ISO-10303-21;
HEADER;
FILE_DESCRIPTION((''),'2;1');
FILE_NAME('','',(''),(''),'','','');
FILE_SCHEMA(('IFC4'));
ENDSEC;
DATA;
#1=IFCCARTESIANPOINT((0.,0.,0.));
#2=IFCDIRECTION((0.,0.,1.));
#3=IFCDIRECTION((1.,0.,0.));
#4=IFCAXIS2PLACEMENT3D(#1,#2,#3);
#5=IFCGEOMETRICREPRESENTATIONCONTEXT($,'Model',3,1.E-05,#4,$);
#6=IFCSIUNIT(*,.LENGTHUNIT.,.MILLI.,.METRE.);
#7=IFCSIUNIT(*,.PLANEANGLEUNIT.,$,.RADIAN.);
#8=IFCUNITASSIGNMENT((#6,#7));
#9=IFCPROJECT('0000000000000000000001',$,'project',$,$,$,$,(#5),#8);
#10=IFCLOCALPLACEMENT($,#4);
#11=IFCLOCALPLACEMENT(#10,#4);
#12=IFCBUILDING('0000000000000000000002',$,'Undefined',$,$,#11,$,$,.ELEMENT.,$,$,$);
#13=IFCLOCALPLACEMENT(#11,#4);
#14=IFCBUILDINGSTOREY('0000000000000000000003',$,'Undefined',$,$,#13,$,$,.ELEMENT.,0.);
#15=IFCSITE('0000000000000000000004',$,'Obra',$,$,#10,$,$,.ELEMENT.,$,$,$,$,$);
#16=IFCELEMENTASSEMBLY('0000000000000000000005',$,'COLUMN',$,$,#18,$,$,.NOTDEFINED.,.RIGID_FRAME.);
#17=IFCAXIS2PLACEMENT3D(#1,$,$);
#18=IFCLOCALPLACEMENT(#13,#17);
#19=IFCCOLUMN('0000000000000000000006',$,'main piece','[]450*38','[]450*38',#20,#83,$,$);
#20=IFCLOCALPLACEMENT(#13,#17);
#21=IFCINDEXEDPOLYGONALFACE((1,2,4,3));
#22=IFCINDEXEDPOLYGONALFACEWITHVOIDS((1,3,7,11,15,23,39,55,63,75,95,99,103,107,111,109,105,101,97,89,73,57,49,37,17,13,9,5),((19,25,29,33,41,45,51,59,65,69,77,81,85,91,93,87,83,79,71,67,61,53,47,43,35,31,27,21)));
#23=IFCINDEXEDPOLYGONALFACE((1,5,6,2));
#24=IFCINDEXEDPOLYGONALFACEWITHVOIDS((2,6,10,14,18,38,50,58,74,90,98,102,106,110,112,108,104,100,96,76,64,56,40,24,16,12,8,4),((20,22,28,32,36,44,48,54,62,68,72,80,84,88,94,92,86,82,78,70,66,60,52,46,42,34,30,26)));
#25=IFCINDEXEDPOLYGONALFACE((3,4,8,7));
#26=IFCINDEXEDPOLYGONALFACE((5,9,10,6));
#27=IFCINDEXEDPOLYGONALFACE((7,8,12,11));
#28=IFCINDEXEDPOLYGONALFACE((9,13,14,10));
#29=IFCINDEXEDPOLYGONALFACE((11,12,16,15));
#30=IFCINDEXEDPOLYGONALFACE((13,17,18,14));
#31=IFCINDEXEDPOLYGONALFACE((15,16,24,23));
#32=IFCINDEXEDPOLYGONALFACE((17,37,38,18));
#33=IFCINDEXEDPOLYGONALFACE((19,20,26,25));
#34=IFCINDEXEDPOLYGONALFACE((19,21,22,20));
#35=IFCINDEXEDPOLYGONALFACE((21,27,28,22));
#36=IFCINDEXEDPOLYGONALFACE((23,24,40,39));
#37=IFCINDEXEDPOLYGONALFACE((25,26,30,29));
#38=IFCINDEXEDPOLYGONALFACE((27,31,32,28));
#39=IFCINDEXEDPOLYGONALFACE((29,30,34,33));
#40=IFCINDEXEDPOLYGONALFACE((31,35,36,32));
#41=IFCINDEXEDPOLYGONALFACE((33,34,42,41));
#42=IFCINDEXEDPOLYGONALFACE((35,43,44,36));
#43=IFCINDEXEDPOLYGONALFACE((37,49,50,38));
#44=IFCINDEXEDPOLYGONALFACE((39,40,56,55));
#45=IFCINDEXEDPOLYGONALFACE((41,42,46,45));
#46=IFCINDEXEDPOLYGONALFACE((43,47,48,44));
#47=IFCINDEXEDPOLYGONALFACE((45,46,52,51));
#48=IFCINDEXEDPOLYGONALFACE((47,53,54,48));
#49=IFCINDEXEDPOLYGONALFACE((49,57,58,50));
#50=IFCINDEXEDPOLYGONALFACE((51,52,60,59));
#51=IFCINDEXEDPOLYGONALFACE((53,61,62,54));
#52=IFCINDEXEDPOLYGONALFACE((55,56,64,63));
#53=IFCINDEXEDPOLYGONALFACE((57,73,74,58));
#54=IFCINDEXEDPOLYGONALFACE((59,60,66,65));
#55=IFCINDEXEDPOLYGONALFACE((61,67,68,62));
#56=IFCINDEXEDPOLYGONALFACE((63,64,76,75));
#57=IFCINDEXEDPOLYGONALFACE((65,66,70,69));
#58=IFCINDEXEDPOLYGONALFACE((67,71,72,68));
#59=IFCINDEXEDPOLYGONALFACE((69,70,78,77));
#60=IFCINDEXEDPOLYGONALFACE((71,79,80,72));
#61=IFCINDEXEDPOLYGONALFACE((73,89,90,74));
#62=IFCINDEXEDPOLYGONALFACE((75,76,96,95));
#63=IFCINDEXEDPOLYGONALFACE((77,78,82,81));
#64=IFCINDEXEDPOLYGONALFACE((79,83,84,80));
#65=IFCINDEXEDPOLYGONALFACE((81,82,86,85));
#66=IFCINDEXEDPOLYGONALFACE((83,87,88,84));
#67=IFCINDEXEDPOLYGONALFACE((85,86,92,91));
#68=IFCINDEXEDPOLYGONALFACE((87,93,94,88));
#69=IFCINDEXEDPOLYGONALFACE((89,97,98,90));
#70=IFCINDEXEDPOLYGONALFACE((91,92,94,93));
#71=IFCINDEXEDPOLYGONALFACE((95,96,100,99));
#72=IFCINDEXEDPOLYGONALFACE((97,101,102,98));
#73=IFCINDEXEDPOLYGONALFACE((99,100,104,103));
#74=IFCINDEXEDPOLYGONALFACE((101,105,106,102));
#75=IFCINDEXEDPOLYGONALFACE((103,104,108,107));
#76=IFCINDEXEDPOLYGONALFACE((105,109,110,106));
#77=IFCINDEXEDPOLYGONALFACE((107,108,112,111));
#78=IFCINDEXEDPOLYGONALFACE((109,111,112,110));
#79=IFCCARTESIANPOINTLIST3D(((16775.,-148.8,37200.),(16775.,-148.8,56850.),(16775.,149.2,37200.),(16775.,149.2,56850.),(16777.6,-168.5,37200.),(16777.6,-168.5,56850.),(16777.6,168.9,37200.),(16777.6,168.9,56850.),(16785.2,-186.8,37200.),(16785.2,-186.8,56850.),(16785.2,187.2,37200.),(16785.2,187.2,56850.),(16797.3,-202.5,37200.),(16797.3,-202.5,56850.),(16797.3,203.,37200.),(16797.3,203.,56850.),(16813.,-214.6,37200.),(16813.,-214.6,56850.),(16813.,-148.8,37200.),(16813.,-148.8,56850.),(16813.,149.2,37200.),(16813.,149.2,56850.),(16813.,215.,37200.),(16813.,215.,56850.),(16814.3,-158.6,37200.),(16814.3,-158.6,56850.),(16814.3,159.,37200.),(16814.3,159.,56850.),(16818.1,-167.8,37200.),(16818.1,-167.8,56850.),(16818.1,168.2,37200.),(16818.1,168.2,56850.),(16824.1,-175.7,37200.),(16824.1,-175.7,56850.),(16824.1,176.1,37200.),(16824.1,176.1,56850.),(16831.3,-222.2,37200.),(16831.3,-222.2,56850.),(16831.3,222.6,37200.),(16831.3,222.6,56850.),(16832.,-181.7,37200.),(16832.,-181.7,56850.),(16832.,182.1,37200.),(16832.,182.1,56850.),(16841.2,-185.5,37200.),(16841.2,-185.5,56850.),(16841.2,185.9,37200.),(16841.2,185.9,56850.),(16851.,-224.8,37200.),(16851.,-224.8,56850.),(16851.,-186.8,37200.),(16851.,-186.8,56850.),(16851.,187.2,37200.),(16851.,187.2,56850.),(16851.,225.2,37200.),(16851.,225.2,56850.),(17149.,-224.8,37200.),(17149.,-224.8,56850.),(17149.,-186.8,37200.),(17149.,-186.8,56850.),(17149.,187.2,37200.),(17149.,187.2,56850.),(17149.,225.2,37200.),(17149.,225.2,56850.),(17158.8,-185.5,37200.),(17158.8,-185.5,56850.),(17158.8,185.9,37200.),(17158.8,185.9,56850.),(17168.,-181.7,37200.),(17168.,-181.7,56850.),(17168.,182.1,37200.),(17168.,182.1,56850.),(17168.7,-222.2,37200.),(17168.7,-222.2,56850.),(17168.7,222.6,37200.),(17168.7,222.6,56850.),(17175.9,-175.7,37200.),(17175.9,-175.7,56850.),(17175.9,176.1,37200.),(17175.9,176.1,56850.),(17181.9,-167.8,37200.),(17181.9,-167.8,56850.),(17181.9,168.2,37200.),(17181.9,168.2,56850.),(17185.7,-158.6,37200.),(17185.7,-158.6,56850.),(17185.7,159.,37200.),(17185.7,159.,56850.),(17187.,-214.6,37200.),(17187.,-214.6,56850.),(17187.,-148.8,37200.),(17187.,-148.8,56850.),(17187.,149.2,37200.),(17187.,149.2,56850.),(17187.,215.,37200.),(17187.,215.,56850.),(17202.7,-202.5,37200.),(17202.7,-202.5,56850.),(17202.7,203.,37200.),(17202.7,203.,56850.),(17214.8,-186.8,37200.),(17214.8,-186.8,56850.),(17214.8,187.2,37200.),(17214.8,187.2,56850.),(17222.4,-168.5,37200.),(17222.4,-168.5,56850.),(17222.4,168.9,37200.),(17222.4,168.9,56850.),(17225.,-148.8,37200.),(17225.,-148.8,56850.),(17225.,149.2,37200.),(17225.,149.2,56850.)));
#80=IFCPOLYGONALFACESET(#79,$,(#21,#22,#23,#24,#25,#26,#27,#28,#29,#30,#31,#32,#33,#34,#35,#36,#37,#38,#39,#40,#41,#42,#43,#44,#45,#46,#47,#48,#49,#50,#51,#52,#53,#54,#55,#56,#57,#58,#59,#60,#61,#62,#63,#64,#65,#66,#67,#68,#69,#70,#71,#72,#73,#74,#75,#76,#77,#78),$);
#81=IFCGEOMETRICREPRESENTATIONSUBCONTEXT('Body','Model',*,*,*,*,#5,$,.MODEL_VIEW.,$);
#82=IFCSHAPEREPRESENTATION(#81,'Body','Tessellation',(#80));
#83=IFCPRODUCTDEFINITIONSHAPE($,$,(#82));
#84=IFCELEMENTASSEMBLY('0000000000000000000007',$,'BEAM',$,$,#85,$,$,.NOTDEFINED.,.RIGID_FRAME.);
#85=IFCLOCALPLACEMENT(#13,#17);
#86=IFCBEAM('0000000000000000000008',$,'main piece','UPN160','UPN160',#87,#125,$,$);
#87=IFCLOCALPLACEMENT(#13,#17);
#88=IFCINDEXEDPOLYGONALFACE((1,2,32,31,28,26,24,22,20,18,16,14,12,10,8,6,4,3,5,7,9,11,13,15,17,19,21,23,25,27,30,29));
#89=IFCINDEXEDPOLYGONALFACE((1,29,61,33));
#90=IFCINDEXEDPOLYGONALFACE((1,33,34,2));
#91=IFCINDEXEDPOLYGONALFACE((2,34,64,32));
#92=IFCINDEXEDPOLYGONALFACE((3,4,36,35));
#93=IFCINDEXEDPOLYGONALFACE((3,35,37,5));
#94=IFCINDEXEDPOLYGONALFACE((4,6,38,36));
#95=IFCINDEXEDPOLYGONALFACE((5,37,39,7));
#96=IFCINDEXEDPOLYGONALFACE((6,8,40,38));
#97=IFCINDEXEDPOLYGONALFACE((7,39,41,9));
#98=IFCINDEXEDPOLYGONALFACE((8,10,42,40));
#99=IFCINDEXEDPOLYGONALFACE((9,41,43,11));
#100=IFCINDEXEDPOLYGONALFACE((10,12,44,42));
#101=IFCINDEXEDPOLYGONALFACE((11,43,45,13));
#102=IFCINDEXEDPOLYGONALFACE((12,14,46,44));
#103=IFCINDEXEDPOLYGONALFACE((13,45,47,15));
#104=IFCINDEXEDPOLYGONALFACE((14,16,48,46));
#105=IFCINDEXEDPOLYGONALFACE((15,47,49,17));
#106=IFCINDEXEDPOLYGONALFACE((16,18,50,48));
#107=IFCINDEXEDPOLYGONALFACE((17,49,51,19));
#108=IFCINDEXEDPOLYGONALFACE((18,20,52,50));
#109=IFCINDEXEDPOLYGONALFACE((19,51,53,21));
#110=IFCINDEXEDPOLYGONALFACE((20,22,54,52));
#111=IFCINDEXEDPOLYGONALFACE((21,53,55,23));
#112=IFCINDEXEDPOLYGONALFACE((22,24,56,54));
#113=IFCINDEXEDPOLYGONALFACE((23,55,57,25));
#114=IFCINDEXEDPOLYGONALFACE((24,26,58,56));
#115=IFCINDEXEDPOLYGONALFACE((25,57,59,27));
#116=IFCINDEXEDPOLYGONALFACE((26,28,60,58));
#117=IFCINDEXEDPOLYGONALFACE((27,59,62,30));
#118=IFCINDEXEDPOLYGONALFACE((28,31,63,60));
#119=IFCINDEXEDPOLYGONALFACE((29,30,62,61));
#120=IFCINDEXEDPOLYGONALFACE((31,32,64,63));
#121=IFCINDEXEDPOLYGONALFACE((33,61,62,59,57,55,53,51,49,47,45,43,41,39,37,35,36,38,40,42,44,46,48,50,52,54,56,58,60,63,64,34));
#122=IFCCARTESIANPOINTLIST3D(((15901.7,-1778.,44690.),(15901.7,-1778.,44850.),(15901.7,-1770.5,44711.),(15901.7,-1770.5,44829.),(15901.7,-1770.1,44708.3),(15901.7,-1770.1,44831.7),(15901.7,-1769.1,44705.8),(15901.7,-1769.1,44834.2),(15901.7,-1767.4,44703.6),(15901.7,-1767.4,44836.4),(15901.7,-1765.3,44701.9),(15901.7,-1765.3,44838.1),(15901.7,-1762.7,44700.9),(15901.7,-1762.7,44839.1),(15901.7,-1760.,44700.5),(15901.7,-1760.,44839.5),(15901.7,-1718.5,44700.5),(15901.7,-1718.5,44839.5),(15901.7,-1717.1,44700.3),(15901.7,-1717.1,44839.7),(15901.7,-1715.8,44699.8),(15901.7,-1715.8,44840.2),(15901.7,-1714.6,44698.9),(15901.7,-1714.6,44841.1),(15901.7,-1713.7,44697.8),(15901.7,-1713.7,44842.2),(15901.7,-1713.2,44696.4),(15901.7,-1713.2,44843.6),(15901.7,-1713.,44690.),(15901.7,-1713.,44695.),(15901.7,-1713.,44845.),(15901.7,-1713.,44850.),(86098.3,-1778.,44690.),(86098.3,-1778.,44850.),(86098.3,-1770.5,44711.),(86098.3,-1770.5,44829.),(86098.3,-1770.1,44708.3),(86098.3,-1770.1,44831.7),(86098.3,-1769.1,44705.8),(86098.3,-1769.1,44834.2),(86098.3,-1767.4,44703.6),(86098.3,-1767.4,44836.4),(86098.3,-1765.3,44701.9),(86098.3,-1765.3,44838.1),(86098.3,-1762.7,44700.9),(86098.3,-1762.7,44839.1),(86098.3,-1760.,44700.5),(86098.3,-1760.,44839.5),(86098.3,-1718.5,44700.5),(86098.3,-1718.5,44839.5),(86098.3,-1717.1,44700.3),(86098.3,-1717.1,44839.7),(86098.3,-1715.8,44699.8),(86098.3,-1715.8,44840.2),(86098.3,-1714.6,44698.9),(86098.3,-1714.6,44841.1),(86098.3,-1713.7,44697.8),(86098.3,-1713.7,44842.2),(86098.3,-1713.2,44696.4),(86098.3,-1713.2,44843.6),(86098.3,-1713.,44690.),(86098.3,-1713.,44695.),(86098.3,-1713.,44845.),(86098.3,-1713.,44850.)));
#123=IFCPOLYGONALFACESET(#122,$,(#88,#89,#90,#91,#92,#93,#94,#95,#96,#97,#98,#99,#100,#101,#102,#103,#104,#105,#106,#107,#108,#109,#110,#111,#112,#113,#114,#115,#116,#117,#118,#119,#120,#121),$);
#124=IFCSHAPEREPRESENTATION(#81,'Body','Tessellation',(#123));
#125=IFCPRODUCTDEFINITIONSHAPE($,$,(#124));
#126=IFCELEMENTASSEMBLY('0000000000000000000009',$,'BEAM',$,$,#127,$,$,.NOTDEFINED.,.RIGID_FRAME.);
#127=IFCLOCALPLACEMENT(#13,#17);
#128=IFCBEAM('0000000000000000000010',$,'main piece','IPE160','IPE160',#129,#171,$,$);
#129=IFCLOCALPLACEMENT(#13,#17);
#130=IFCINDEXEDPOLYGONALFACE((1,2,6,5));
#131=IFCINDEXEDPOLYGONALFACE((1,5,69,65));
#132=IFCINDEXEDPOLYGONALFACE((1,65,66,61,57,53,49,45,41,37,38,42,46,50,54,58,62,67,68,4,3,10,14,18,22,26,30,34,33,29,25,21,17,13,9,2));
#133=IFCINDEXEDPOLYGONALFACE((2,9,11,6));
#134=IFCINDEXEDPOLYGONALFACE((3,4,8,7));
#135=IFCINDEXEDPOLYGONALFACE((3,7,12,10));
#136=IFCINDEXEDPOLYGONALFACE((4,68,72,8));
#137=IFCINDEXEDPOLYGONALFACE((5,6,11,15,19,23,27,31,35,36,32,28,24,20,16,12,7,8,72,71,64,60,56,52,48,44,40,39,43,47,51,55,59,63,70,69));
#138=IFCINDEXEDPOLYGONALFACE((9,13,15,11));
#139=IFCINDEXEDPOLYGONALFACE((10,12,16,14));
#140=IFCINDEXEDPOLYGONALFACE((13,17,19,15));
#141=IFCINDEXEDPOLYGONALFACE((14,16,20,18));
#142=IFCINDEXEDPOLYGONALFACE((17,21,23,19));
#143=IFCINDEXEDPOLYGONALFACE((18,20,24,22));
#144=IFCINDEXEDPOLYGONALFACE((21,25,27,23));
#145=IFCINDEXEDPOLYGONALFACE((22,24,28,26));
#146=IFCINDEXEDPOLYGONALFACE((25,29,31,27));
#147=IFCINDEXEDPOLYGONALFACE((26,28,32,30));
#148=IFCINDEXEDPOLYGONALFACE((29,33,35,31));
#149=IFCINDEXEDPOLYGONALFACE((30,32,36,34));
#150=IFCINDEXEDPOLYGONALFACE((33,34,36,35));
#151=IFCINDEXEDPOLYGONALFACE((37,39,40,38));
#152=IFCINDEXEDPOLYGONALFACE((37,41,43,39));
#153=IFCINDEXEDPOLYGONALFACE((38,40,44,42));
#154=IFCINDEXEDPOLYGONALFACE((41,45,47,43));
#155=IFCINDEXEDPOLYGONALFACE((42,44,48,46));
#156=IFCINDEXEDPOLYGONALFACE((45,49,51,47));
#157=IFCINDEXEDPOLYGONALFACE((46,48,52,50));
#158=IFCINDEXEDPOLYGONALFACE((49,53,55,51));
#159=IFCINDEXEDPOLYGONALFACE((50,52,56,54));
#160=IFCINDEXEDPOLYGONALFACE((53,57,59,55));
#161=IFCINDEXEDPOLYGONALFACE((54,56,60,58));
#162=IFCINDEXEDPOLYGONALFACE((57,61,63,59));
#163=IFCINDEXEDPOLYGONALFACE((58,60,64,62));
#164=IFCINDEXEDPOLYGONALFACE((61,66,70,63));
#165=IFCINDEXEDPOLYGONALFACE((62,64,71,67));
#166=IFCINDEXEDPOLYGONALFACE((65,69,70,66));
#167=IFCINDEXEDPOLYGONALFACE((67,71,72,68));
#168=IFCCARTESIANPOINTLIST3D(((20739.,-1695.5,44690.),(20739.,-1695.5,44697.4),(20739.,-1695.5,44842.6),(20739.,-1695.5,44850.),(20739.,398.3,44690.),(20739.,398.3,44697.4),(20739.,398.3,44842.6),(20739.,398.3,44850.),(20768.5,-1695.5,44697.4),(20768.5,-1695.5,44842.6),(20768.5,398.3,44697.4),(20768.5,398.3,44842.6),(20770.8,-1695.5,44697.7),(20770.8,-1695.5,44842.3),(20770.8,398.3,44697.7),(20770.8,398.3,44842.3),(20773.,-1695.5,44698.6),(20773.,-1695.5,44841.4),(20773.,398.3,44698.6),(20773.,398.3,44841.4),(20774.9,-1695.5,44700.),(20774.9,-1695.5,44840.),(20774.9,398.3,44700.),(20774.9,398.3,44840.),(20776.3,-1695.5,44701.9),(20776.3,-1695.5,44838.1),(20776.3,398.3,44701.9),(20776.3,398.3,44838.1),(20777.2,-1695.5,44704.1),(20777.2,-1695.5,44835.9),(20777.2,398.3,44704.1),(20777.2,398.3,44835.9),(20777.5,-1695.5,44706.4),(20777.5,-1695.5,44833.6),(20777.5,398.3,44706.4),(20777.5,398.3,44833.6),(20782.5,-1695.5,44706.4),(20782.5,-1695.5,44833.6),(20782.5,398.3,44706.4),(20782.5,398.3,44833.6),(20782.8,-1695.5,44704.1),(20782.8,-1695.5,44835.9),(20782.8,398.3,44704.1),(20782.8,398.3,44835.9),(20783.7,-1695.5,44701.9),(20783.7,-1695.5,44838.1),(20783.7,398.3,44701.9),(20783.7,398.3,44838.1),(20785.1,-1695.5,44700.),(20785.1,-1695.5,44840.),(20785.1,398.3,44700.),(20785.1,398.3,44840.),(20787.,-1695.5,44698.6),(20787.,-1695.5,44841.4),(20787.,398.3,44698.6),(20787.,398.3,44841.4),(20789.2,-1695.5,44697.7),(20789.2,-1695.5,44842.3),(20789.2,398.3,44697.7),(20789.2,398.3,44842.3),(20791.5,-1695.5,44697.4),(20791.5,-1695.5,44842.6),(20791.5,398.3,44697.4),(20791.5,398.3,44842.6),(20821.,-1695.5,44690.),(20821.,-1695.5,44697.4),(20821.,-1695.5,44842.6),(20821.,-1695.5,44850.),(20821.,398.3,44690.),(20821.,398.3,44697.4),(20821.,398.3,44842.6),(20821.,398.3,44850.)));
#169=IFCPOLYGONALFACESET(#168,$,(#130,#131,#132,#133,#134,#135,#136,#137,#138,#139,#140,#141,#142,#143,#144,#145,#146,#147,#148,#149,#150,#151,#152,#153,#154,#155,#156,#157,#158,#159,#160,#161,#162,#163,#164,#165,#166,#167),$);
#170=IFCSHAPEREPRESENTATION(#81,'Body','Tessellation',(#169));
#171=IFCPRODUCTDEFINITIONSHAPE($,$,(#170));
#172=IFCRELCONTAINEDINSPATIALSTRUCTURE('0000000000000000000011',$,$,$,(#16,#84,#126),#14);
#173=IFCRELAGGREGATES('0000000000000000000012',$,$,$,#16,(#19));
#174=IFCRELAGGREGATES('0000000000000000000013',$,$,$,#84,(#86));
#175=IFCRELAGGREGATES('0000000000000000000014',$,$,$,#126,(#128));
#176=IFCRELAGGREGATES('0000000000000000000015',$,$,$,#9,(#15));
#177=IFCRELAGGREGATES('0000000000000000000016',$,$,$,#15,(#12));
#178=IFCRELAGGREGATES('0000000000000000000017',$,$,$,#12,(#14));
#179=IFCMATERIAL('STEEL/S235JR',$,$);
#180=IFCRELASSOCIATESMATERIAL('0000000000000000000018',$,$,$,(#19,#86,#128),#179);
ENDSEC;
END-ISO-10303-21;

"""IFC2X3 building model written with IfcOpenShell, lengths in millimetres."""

from ifc_helpers import new_model, si_unit, frame, origin_with_axes, origin_2d_with_axis, place, context, subcontext, project, spatial, hollow_rectangle, i_section, u_section, extrude, material, element, aggregate, save


model = new_model("IFC2X3")

# Units and contexts
model_context = context("Model", 3, precision=1e-05, world=origin_with_axes())
body_context = subcontext(model_context, "Body", "Model", "MODEL_VIEW")
ifc_project = project(units=[si_unit("LENGTHUNIT", "METRE", prefix="MILLI"), si_unit("PLANEANGLEUNIT", "RADIAN")], contexts=[model_context])

# Site, building, storey
site_placement = place(None, origin_with_axes())
site = spatial("IfcSite", under=ifc_project, at=site_placement, Name="Obra", CompositionType="ELEMENT")
building_placement = place(site_placement, origin_with_axes())
building = spatial("IfcBuilding", under=site, at=building_placement, Name="Undefined", CompositionType="ELEMENT")
storey_placement = place(building_placement, origin_with_axes())
storey = spatial("IfcBuildingStorey", under=building, at=storey_placement, Name="Undefined", CompositionType="ELEMENT", Elevation=0.0)

# Element assembly, column
assembly_1_placement = place(storey_placement, origin_with_axes())
assembly_1 = element("IfcElementAssembly", 1, at=assembly_1_placement, inside=storey, Name="COLUMN", AssemblyPlace="NOTDEFINED", PredefinedType="RIGID_FRAME")
ifc_material = material(Name="STEEL/S235JR")
column_placement = place(assembly_1_placement, frame((17000.0, 0.2, 37200.0), z_axis=(0.0, 0.0, 1.0), x_axis=(0.0, 1.0, 0.0)))
column = element("IfcColumn", 2, at=column_placement, material=ifc_material, Name="main piece", Description="[]450*38", ObjectType="[]450*38", context=body_context, shape_type="SweptSolid", body=[
    extrude(hollow_rectangle(XDim=450.0, YDim=450.0, WallThickness=38.0, InnerFilletRadius=38.0, OuterFilletRadius=76.0, at=origin_2d_with_axis()), frame((0.0, 0.0, 19650.0), z_axis=(0.0, 0.0, -1.0), x_axis=(0.0, 1.0, 0.0)), (0.0, 0.0, 1.0), 19650.0),
])
aggregate(assembly_1, [column])

# Element assemblies, beams
assembly_2_placement = place(storey_placement, origin_with_axes())
assembly_2 = element("IfcElementAssembly", 3, at=assembly_2_placement, inside=storey, Name="BEAM", AssemblyPlace="NOTDEFINED", PredefinedType="RIGID_FRAME")
beam_1_placement = place(assembly_2_placement, frame((15901.7, -1745.5, 44770.0), z_axis=(0.0, 0.0, -1.0), x_axis=(1.0, 0.0, 0.0)))
beam_1 = element("IfcBeam", 4, at=beam_1_placement, material=ifc_material, Name="main piece", Description="UPN160", ObjectType="UPN160", context=body_context, shape_type="SweptSolid", body=[
    extrude(u_section(Depth=160.0, FlangeWidth=65.0, WebThickness=7.5, FlangeThickness=10.5, FilletRadius=10.5, EdgeRadius=5.5, at=origin_2d_with_axis()), frame((70196.6, 0.0, 0.0), z_axis=(-1.0, 0.0, 0.0), x_axis=(0.0, -1.0, 0.0)), (0.0, 0.0, 1.0), 70196.6),
])
aggregate(assembly_2, [beam_1])
assembly_3_placement = place(storey_placement, origin_with_axes())
assembly_3 = element("IfcElementAssembly", 5, at=assembly_3_placement, inside=storey, Name="BEAM", AssemblyPlace="NOTDEFINED", PredefinedType="RIGID_FRAME")
beam_2_placement = place(assembly_3_placement, frame((20780.0, 398.3, 44770.0), z_axis=(0.0, 0.0, 1.0), x_axis=(0.0, -1.0, 0.0)))
beam_2 = element("IfcBeam", 6, at=beam_2_placement, material=ifc_material, Name="main piece", Description="IPE160", ObjectType="IPE160", context=body_context, shape_type="SweptSolid", body=[
    extrude(i_section(OverallWidth=82.0, OverallDepth=160.0, WebThickness=5.0, FlangeThickness=7.4, FilletRadius=9.0, at=origin_2d_with_axis()), frame((2093.8, 0.0, 0.0), z_axis=(-1.0, 0.0, 0.0), x_axis=(0.0, -1.0, 0.0)), (0.0, 0.0, 1.0), 2093.8),
])
aggregate(assembly_3, [beam_2])

save(model, "model.ifc")
